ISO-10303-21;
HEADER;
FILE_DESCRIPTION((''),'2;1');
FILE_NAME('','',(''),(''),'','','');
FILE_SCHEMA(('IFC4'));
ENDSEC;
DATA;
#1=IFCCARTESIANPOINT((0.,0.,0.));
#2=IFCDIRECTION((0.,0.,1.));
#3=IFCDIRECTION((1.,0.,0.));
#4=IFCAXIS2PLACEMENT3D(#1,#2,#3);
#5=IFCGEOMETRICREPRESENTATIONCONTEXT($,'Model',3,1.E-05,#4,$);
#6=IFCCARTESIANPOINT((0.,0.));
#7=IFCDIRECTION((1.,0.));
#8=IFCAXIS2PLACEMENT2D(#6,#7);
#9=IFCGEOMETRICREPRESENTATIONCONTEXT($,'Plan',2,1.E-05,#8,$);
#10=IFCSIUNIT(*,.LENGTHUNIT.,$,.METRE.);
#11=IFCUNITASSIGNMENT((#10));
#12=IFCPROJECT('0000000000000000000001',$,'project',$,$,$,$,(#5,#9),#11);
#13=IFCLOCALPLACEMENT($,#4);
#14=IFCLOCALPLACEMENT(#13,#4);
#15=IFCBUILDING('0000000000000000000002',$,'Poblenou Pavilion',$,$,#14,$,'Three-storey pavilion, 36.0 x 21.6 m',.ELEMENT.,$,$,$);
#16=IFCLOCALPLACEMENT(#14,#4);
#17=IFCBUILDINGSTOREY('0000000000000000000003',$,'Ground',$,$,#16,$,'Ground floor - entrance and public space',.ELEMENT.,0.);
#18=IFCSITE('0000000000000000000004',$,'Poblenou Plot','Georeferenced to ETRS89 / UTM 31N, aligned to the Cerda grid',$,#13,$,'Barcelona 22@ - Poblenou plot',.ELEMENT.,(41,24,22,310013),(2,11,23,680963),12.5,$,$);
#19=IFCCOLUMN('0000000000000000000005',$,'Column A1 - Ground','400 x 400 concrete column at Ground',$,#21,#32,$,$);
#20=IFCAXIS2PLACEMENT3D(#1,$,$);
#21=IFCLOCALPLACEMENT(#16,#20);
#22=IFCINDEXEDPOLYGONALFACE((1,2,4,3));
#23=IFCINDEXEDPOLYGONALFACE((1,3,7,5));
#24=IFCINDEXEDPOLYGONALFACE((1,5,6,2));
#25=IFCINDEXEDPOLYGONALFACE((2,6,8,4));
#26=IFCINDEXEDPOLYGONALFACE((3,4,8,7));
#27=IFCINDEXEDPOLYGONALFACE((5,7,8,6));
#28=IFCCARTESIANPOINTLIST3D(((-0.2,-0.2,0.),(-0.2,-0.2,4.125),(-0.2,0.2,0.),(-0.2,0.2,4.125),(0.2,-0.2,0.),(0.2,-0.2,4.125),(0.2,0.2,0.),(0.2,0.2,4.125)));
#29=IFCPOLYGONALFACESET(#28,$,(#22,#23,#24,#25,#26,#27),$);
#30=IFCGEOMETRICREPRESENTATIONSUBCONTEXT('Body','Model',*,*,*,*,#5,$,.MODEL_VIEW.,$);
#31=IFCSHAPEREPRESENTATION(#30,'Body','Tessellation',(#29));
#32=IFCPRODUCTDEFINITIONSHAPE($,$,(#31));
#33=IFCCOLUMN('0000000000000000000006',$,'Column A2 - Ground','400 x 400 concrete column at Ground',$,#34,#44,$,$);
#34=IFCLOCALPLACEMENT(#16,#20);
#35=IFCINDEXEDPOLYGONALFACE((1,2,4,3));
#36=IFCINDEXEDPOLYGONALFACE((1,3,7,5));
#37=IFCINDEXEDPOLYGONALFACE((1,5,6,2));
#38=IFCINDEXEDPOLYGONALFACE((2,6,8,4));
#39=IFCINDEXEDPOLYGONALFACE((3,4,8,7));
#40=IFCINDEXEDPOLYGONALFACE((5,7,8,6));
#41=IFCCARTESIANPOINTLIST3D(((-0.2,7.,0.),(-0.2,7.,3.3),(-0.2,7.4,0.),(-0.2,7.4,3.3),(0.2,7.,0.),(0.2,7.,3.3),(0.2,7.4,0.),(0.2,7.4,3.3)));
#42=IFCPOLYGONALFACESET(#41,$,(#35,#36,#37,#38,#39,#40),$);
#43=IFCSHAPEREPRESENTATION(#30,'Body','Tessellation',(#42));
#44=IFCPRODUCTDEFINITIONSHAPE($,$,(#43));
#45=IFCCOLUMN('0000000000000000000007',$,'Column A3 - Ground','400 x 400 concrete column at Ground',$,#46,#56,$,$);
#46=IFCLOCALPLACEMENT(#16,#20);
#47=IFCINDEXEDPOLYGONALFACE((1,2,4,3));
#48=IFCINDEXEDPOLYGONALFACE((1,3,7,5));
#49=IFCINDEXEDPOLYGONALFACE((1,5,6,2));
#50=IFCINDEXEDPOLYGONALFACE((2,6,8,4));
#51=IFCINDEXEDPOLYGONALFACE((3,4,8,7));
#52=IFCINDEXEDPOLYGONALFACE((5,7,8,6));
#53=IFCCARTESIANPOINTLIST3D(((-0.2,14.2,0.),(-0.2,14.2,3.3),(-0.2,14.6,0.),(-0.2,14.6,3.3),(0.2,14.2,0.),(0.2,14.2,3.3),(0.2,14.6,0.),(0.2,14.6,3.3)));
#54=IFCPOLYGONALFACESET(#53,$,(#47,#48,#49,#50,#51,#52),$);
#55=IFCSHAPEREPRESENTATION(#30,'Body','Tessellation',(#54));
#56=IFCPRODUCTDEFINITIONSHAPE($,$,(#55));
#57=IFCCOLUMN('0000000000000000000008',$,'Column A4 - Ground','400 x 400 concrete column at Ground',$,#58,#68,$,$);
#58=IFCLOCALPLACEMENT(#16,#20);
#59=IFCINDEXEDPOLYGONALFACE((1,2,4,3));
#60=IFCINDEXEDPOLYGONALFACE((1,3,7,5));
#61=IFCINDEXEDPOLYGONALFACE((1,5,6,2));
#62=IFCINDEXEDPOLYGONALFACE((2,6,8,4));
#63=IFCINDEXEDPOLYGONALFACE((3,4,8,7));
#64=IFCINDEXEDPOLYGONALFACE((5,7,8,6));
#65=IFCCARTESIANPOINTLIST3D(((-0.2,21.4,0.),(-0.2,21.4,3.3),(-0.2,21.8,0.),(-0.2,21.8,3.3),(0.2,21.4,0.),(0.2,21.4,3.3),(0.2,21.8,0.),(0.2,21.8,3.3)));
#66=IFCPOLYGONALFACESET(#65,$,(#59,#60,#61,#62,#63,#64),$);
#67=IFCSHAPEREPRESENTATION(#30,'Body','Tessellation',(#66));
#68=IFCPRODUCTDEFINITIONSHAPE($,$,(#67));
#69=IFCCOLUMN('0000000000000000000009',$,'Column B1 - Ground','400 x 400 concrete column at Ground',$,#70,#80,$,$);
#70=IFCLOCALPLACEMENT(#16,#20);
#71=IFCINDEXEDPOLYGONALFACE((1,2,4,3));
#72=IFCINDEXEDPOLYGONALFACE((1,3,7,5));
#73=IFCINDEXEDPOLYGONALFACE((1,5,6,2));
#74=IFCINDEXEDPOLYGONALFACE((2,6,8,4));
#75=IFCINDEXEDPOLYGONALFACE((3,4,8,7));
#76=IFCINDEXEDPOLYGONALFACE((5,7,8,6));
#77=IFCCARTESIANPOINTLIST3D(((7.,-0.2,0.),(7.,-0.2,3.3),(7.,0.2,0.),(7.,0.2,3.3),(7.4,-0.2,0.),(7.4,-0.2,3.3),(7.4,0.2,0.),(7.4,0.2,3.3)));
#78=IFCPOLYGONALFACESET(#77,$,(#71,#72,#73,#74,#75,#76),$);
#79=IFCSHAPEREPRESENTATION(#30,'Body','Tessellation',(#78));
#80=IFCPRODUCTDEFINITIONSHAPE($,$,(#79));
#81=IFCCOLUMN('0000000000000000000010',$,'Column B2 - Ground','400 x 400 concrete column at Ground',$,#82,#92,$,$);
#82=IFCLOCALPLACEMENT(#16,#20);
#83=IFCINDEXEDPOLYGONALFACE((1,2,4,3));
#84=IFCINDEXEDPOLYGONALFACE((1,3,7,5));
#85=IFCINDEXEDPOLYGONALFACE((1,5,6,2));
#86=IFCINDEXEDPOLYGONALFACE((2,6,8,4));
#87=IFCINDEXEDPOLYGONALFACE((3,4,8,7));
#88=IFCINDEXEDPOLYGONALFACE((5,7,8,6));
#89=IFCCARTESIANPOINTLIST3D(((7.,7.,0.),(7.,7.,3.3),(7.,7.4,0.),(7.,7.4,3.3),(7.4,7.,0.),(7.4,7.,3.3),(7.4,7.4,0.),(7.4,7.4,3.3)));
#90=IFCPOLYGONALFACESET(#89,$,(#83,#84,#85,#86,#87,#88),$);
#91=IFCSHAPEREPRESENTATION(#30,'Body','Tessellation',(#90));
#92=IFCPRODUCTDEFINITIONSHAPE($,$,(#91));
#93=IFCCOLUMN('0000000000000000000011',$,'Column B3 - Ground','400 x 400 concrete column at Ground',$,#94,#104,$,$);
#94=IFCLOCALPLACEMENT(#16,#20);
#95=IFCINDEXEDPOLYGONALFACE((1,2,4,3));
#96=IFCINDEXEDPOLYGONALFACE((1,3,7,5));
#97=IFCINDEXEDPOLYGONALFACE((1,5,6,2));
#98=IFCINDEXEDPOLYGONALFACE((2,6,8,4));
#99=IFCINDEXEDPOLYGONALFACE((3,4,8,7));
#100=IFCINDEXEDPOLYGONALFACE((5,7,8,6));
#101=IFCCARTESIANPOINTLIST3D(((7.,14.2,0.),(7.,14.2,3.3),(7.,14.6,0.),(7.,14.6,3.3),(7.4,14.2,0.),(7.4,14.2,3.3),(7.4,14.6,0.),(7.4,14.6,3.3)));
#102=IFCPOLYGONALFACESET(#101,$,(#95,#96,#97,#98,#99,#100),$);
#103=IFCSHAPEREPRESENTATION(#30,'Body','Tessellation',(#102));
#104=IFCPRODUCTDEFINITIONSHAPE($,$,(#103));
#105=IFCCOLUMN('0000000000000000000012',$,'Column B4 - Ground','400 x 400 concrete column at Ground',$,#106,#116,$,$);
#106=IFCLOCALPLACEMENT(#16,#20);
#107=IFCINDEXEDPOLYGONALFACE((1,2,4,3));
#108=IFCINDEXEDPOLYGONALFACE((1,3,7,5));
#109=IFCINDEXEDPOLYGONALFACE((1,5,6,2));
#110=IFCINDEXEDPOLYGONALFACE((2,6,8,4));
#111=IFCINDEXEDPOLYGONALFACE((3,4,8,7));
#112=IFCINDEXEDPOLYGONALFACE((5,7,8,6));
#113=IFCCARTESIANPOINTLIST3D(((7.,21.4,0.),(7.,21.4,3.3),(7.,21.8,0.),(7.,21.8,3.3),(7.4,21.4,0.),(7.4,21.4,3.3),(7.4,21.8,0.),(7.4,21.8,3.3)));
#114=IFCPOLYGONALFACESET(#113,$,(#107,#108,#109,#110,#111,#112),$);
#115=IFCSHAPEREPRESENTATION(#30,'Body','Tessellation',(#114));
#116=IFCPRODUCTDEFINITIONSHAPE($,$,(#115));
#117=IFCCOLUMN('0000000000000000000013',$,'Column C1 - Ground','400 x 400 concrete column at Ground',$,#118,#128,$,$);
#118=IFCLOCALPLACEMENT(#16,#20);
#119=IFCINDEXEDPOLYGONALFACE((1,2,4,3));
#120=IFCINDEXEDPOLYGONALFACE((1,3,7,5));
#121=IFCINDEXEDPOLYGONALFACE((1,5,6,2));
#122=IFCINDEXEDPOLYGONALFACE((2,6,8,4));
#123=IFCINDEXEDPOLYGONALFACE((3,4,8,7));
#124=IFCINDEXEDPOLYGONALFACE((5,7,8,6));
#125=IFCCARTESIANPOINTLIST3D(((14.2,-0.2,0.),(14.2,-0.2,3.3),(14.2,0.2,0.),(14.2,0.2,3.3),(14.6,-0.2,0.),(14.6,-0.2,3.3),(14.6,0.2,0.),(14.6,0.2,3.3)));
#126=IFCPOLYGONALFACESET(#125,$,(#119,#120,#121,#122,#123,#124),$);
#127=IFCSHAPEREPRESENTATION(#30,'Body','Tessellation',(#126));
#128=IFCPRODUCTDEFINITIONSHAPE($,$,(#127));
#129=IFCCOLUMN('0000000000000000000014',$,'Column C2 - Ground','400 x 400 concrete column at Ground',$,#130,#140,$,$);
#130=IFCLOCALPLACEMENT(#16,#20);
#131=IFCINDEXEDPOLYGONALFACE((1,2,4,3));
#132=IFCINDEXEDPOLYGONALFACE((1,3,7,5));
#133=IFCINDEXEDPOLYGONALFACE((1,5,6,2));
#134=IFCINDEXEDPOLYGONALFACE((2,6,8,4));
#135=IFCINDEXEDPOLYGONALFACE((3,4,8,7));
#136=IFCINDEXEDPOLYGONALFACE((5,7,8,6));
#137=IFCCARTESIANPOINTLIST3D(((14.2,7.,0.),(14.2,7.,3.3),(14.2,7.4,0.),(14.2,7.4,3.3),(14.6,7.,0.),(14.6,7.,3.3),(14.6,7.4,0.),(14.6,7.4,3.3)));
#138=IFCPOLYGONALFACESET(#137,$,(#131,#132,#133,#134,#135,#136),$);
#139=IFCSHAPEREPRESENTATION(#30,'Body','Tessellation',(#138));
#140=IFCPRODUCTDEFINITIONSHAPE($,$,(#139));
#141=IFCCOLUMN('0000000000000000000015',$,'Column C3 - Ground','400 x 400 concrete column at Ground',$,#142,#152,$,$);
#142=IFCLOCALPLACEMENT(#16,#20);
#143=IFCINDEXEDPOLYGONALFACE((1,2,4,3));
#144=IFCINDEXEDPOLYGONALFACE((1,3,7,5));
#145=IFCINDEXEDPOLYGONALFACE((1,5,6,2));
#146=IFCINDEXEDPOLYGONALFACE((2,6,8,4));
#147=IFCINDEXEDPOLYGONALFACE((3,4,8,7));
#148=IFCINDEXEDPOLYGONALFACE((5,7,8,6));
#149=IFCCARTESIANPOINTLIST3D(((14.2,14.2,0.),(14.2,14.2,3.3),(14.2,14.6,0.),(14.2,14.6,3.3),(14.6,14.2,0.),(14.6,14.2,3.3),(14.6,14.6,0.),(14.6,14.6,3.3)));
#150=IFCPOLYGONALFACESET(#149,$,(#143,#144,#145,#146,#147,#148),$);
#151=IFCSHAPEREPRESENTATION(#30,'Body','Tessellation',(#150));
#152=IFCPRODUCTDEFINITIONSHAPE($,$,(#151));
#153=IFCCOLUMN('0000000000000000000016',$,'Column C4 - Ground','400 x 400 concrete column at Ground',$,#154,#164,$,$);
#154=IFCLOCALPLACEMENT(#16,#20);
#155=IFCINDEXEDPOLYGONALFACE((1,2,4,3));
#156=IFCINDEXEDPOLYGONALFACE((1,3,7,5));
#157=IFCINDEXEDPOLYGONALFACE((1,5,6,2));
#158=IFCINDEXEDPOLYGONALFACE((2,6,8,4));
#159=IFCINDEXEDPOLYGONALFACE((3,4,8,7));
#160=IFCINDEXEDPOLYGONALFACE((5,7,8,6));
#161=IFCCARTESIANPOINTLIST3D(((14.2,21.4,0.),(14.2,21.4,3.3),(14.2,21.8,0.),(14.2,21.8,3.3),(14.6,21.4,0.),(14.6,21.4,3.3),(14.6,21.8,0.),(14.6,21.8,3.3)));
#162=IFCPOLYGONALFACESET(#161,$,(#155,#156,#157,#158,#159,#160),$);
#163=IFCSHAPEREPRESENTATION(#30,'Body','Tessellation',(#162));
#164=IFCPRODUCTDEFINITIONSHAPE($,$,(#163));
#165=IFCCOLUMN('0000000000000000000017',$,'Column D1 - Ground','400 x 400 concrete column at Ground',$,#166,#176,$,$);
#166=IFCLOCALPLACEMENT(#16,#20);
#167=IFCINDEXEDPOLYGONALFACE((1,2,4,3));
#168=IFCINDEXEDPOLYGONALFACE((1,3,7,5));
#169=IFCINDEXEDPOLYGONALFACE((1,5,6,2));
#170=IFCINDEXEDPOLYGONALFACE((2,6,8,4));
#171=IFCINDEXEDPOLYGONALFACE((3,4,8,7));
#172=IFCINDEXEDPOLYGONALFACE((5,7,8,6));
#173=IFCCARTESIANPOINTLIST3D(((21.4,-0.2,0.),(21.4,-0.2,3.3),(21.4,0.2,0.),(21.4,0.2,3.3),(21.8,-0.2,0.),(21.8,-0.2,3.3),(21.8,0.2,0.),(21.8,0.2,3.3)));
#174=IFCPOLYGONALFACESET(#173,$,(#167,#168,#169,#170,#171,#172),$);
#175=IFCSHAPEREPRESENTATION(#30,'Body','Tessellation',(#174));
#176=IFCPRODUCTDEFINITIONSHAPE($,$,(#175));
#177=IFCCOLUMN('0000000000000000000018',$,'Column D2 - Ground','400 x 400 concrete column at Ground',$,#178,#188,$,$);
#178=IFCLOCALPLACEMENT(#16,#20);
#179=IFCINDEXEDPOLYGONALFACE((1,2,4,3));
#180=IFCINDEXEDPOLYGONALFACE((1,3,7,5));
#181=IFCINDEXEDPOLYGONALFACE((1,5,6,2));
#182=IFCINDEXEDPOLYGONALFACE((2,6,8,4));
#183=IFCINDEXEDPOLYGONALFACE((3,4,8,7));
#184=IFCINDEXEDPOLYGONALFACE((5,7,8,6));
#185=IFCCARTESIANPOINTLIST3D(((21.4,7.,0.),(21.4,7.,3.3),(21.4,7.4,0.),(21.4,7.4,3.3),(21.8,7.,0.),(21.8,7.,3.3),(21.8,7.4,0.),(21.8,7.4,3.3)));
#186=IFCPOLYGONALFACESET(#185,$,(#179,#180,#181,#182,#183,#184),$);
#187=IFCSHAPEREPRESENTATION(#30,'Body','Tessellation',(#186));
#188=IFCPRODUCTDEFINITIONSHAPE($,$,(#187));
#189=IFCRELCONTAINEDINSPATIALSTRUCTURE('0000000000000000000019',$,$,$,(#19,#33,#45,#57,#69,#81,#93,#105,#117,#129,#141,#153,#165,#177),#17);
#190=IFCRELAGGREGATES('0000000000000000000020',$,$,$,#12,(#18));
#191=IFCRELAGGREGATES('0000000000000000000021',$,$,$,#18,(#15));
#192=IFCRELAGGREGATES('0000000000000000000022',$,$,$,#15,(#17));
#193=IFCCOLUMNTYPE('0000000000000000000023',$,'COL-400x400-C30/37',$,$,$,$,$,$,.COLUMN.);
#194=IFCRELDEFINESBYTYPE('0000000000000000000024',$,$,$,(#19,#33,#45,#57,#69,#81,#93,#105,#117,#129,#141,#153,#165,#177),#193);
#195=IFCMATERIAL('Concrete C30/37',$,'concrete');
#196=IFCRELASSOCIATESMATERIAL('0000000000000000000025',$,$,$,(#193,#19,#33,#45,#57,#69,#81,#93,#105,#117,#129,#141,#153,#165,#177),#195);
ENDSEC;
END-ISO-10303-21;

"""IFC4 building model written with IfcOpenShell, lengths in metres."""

from ifc_helpers import new_model, si_unit, frame, origin_with_axes, origin_2d_with_axis, place, context, subcontext, project, spatial, line, indexed_curve, rectangle, outline, extrude, material, material_profile, profile_set, profile_usage, type_object, element, save


model = new_model("IFC4")

# Units and contexts
model_context = context("Model", 3, precision=1e-05, world=origin_with_axes())
plan_context = context("Plan", 2, precision=1e-05, world=origin_2d_with_axis())
body_context = subcontext(model_context, "Body", "Model", "MODEL_VIEW")
ifc_project = project(units=[si_unit("LENGTHUNIT", "METRE")], contexts=[model_context, plan_context])

# Site, building, storey
site_placement = place(None, origin_with_axes())
site = spatial("IfcSite", under=ifc_project, at=site_placement, Name="Poblenou Plot", Description="Georeferenced to ETRS89 / UTM 31N, aligned to the Cerda grid", LongName="Barcelona 22@ - Poblenou plot", CompositionType="ELEMENT", RefLatitude=(41, 24, 22, 310013), RefLongitude=(2, 11, 23, 680963), RefElevation=12.5)
building_placement = place(site_placement, origin_with_axes())
building = spatial("IfcBuilding", under=site, at=building_placement, Name="Poblenou Pavilion", LongName="Three-storey pavilion, 36.0 x 21.6 m", CompositionType="ELEMENT")
storey_placement = place(building_placement, origin_with_axes())
storey = spatial("IfcBuildingStorey", under=building, at=storey_placement, Name="Ground", LongName="Ground floor - entrance and public space", CompositionType="ELEMENT", Elevation=0.0)

# Columns
ifc_material = material(Name="Concrete C30/37", Category="concrete")
ifc_material_profile = material_profile(ifc_material, rectangle(XDim=0.4, YDim=0.4))
ifc_profile_set = profile_set([ifc_material_profile], Name="COL-400x400-C30/37")
ifc_profile_usage_1 = profile_usage(ifc_profile_set)
column_type = type_object("IfcColumnType", Name="COL-400x400-C30/37", PredefinedType="COLUMN", material=ifc_profile_set)
column_1_placement = place(storey_placement, frame((-0.2, -0.2, 0.0), z_axis=(0.0, 0.0, 1.0), x_axis=(1.0, 0.0, 0.0)))
element("IfcColumn", 1, at=column_1_placement, inside=storey, type_object=column_type, material=ifc_profile_usage_1, Name="Column A1 - Ground", Description="400 x 400 concrete column at Ground", context=body_context, shape_type="SweptSolid", body=[
    extrude(outline(indexed_curve([(0.0, 0.0), (0.4, 0.0), (0.4, 0.4), (0.0, 0.4)], segments=[line(1, 2, 3, 4, 1)])), origin_with_axes(), (0.0, 0.0, 1.0), 4.125),
])
ifc_profile_usage_2 = profile_usage(ifc_profile_set)
column_2_placement = place(storey_placement, frame((-0.2, 7.0, 0.0), z_axis=(0.0, 0.0, 1.0), x_axis=(1.0, 0.0, 0.0)))
element("IfcColumn", 2, at=column_2_placement, inside=storey, type_object=column_type, material=ifc_profile_usage_2, Name="Column A2 - Ground", Description="400 x 400 concrete column at Ground", context=body_context, shape_type="SweptSolid", body=[
    extrude(outline(indexed_curve([(0.0, 0.0), (0.4, 0.0), (0.4, 0.4), (0.0, 0.4)], segments=[line(1, 2, 3, 4, 1)])), origin_with_axes(), (0.0, 0.0, 1.0), 3.3),
])
ifc_profile_usage_3 = profile_usage(ifc_profile_set)
column_3_placement = place(storey_placement, frame((-0.2, 14.2, 0.0), z_axis=(0.0, 0.0, 1.0), x_axis=(1.0, 0.0, 0.0)))
element("IfcColumn", 3, at=column_3_placement, inside=storey, type_object=column_type, material=ifc_profile_usage_3, Name="Column A3 - Ground", Description="400 x 400 concrete column at Ground", context=body_context, shape_type="SweptSolid", body=[
    extrude(outline(indexed_curve([(0.0, 0.0), (0.4, 0.0), (0.4, 0.4), (0.0, 0.4)], segments=[line(1, 2, 3, 4, 1)])), origin_with_axes(), (0.0, 0.0, 1.0), 3.3),
])
ifc_profile_usage_4 = profile_usage(ifc_profile_set)
column_4_placement = place(storey_placement, frame((-0.2, 21.4, 0.0), z_axis=(0.0, 0.0, 1.0), x_axis=(1.0, 0.0, 0.0)))
element("IfcColumn", 4, at=column_4_placement, inside=storey, type_object=column_type, material=ifc_profile_usage_4, Name="Column A4 - Ground", Description="400 x 400 concrete column at Ground", context=body_context, shape_type="SweptSolid", body=[
    extrude(outline(indexed_curve([(0.0, 0.0), (0.4, 0.0), (0.4, 0.4), (0.0, 0.4)], segments=[line(1, 2, 3, 4, 1)])), origin_with_axes(), (0.0, 0.0, 1.0), 3.3),
])
ifc_profile_usage_5 = profile_usage(ifc_profile_set)
column_5_placement = place(storey_placement, frame((7.0, -0.2, 0.0), z_axis=(0.0, 0.0, 1.0), x_axis=(1.0, 0.0, 0.0)))
element("IfcColumn", 5, at=column_5_placement, inside=storey, type_object=column_type, material=ifc_profile_usage_5, Name="Column B1 - Ground", Description="400 x 400 concrete column at Ground", context=body_context, shape_type="SweptSolid", body=[
    extrude(outline(indexed_curve([(0.0, 0.0), (0.4, 0.0), (0.4, 0.4), (0.0, 0.4)], segments=[line(1, 2, 3, 4, 1)])), origin_with_axes(), (0.0, 0.0, 1.0), 3.3),
])
ifc_profile_usage_6 = profile_usage(ifc_profile_set)
column_6_placement = place(storey_placement, frame((7.0, 7.0, 0.0), z_axis=(0.0, 0.0, 1.0), x_axis=(1.0, 0.0, 0.0)))
element("IfcColumn", 6, at=column_6_placement, inside=storey, type_object=column_type, material=ifc_profile_usage_6, Name="Column B2 - Ground", Description="400 x 400 concrete column at Ground", context=body_context, shape_type="SweptSolid", body=[
    extrude(outline(indexed_curve([(0.0, 0.0), (0.4, 0.0), (0.4, 0.4), (0.0, 0.4)], segments=[line(1, 2, 3, 4, 1)])), origin_with_axes(), (0.0, 0.0, 1.0), 3.3),
])
ifc_profile_usage_7 = profile_usage(ifc_profile_set)
column_7_placement = place(storey_placement, frame((7.0, 14.2, 0.0), z_axis=(0.0, 0.0, 1.0), x_axis=(1.0, 0.0, 0.0)))
element("IfcColumn", 7, at=column_7_placement, inside=storey, type_object=column_type, material=ifc_profile_usage_7, Name="Column B3 - Ground", Description="400 x 400 concrete column at Ground", context=body_context, shape_type="SweptSolid", body=[
    extrude(outline(indexed_curve([(0.0, 0.0), (0.4, 0.0), (0.4, 0.4), (0.0, 0.4)], segments=[line(1, 2, 3, 4, 1)])), origin_with_axes(), (0.0, 0.0, 1.0), 3.3),
])
ifc_profile_usage_8 = profile_usage(ifc_profile_set)
column_8_placement = place(storey_placement, frame((7.0, 21.4, 0.0), z_axis=(0.0, 0.0, 1.0), x_axis=(1.0, 0.0, 0.0)))
element("IfcColumn", 8, at=column_8_placement, inside=storey, type_object=column_type, material=ifc_profile_usage_8, Name="Column B4 - Ground", Description="400 x 400 concrete column at Ground", context=body_context, shape_type="SweptSolid", body=[
    extrude(outline(indexed_curve([(0.0, 0.0), (0.4, 0.0), (0.4, 0.4), (0.0, 0.4)], segments=[line(1, 2, 3, 4, 1)])), origin_with_axes(), (0.0, 0.0, 1.0), 3.3),
])
ifc_profile_usage_9 = profile_usage(ifc_profile_set)
column_9_placement = place(storey_placement, frame((14.2, -0.2, 0.0), z_axis=(0.0, 0.0, 1.0), x_axis=(1.0, 0.0, 0.0)))
element("IfcColumn", 9, at=column_9_placement, inside=storey, type_object=column_type, material=ifc_profile_usage_9, Name="Column C1 - Ground", Description="400 x 400 concrete column at Ground", context=body_context, shape_type="SweptSolid", body=[
    extrude(outline(indexed_curve([(0.0, 0.0), (0.4, 0.0), (0.4, 0.4), (0.0, 0.4)], segments=[line(1, 2, 3, 4, 1)])), origin_with_axes(), (0.0, 0.0, 1.0), 3.3),
])
ifc_profile_usage_10 = profile_usage(ifc_profile_set)
column_10_placement = place(storey_placement, frame((14.2, 7.0, 0.0), z_axis=(0.0, 0.0, 1.0), x_axis=(1.0, 0.0, 0.0)))
element("IfcColumn", 10, at=column_10_placement, inside=storey, type_object=column_type, material=ifc_profile_usage_10, Name="Column C2 - Ground", Description="400 x 400 concrete column at Ground", context=body_context, shape_type="SweptSolid", body=[
    extrude(outline(indexed_curve([(0.0, 0.0), (0.4, 0.0), (0.4, 0.4), (0.0, 0.4)], segments=[line(1, 2, 3, 4, 1)])), origin_with_axes(), (0.0, 0.0, 1.0), 3.3),
])
ifc_profile_usage_11 = profile_usage(ifc_profile_set)
column_11_placement = place(storey_placement, frame((14.2, 14.2, 0.0), z_axis=(0.0, 0.0, 1.0), x_axis=(1.0, 0.0, 0.0)))
element("IfcColumn", 11, at=column_11_placement, inside=storey, type_object=column_type, material=ifc_profile_usage_11, Name="Column C3 - Ground", Description="400 x 400 concrete column at Ground", context=body_context, shape_type="SweptSolid", body=[
    extrude(outline(indexed_curve([(0.0, 0.0), (0.4, 0.0), (0.4, 0.4), (0.0, 0.4)], segments=[line(1, 2, 3, 4, 1)])), origin_with_axes(), (0.0, 0.0, 1.0), 3.3),
])
ifc_profile_usage_12 = profile_usage(ifc_profile_set)
column_12_placement = place(storey_placement, frame((14.2, 21.4, 0.0), z_axis=(0.0, 0.0, 1.0), x_axis=(1.0, 0.0, 0.0)))
element("IfcColumn", 12, at=column_12_placement, inside=storey, type_object=column_type, material=ifc_profile_usage_12, Name="Column C4 - Ground", Description="400 x 400 concrete column at Ground", context=body_context, shape_type="SweptSolid", body=[
    extrude(outline(indexed_curve([(0.0, 0.0), (0.4, 0.0), (0.4, 0.4), (0.0, 0.4)], segments=[line(1, 2, 3, 4, 1)])), origin_with_axes(), (0.0, 0.0, 1.0), 3.3),
])
ifc_profile_usage_13 = profile_usage(ifc_profile_set)
column_13_placement = place(storey_placement, frame((21.4, -0.2, 0.0), z_axis=(0.0, 0.0, 1.0), x_axis=(1.0, 0.0, 0.0)))
element("IfcColumn", 13, at=column_13_placement, inside=storey, type_object=column_type, material=ifc_profile_usage_13, Name="Column D1 - Ground", Description="400 x 400 concrete column at Ground", context=body_context, shape_type="SweptSolid", body=[
    extrude(outline(indexed_curve([(0.0, 0.0), (0.4, 0.0), (0.4, 0.4), (0.0, 0.4)], segments=[line(1, 2, 3, 4, 1)])), origin_with_axes(), (0.0, 0.0, 1.0), 3.3),
])
ifc_profile_usage_14 = profile_usage(ifc_profile_set)
column_14_placement = place(storey_placement, frame((21.4, 7.0, 0.0), z_axis=(0.0, 0.0, 1.0), x_axis=(1.0, 0.0, 0.0)))
element("IfcColumn", 14, at=column_14_placement, inside=storey, type_object=column_type, material=ifc_profile_usage_14, Name="Column D2 - Ground", Description="400 x 400 concrete column at Ground", context=body_context, shape_type="SweptSolid", body=[
    extrude(outline(indexed_curve([(0.0, 0.0), (0.4, 0.0), (0.4, 0.4), (0.0, 0.4)], segments=[line(1, 2, 3, 4, 1)])), origin_with_axes(), (0.0, 0.0, 1.0), 3.3),
])

save(model, "model.ifc")
